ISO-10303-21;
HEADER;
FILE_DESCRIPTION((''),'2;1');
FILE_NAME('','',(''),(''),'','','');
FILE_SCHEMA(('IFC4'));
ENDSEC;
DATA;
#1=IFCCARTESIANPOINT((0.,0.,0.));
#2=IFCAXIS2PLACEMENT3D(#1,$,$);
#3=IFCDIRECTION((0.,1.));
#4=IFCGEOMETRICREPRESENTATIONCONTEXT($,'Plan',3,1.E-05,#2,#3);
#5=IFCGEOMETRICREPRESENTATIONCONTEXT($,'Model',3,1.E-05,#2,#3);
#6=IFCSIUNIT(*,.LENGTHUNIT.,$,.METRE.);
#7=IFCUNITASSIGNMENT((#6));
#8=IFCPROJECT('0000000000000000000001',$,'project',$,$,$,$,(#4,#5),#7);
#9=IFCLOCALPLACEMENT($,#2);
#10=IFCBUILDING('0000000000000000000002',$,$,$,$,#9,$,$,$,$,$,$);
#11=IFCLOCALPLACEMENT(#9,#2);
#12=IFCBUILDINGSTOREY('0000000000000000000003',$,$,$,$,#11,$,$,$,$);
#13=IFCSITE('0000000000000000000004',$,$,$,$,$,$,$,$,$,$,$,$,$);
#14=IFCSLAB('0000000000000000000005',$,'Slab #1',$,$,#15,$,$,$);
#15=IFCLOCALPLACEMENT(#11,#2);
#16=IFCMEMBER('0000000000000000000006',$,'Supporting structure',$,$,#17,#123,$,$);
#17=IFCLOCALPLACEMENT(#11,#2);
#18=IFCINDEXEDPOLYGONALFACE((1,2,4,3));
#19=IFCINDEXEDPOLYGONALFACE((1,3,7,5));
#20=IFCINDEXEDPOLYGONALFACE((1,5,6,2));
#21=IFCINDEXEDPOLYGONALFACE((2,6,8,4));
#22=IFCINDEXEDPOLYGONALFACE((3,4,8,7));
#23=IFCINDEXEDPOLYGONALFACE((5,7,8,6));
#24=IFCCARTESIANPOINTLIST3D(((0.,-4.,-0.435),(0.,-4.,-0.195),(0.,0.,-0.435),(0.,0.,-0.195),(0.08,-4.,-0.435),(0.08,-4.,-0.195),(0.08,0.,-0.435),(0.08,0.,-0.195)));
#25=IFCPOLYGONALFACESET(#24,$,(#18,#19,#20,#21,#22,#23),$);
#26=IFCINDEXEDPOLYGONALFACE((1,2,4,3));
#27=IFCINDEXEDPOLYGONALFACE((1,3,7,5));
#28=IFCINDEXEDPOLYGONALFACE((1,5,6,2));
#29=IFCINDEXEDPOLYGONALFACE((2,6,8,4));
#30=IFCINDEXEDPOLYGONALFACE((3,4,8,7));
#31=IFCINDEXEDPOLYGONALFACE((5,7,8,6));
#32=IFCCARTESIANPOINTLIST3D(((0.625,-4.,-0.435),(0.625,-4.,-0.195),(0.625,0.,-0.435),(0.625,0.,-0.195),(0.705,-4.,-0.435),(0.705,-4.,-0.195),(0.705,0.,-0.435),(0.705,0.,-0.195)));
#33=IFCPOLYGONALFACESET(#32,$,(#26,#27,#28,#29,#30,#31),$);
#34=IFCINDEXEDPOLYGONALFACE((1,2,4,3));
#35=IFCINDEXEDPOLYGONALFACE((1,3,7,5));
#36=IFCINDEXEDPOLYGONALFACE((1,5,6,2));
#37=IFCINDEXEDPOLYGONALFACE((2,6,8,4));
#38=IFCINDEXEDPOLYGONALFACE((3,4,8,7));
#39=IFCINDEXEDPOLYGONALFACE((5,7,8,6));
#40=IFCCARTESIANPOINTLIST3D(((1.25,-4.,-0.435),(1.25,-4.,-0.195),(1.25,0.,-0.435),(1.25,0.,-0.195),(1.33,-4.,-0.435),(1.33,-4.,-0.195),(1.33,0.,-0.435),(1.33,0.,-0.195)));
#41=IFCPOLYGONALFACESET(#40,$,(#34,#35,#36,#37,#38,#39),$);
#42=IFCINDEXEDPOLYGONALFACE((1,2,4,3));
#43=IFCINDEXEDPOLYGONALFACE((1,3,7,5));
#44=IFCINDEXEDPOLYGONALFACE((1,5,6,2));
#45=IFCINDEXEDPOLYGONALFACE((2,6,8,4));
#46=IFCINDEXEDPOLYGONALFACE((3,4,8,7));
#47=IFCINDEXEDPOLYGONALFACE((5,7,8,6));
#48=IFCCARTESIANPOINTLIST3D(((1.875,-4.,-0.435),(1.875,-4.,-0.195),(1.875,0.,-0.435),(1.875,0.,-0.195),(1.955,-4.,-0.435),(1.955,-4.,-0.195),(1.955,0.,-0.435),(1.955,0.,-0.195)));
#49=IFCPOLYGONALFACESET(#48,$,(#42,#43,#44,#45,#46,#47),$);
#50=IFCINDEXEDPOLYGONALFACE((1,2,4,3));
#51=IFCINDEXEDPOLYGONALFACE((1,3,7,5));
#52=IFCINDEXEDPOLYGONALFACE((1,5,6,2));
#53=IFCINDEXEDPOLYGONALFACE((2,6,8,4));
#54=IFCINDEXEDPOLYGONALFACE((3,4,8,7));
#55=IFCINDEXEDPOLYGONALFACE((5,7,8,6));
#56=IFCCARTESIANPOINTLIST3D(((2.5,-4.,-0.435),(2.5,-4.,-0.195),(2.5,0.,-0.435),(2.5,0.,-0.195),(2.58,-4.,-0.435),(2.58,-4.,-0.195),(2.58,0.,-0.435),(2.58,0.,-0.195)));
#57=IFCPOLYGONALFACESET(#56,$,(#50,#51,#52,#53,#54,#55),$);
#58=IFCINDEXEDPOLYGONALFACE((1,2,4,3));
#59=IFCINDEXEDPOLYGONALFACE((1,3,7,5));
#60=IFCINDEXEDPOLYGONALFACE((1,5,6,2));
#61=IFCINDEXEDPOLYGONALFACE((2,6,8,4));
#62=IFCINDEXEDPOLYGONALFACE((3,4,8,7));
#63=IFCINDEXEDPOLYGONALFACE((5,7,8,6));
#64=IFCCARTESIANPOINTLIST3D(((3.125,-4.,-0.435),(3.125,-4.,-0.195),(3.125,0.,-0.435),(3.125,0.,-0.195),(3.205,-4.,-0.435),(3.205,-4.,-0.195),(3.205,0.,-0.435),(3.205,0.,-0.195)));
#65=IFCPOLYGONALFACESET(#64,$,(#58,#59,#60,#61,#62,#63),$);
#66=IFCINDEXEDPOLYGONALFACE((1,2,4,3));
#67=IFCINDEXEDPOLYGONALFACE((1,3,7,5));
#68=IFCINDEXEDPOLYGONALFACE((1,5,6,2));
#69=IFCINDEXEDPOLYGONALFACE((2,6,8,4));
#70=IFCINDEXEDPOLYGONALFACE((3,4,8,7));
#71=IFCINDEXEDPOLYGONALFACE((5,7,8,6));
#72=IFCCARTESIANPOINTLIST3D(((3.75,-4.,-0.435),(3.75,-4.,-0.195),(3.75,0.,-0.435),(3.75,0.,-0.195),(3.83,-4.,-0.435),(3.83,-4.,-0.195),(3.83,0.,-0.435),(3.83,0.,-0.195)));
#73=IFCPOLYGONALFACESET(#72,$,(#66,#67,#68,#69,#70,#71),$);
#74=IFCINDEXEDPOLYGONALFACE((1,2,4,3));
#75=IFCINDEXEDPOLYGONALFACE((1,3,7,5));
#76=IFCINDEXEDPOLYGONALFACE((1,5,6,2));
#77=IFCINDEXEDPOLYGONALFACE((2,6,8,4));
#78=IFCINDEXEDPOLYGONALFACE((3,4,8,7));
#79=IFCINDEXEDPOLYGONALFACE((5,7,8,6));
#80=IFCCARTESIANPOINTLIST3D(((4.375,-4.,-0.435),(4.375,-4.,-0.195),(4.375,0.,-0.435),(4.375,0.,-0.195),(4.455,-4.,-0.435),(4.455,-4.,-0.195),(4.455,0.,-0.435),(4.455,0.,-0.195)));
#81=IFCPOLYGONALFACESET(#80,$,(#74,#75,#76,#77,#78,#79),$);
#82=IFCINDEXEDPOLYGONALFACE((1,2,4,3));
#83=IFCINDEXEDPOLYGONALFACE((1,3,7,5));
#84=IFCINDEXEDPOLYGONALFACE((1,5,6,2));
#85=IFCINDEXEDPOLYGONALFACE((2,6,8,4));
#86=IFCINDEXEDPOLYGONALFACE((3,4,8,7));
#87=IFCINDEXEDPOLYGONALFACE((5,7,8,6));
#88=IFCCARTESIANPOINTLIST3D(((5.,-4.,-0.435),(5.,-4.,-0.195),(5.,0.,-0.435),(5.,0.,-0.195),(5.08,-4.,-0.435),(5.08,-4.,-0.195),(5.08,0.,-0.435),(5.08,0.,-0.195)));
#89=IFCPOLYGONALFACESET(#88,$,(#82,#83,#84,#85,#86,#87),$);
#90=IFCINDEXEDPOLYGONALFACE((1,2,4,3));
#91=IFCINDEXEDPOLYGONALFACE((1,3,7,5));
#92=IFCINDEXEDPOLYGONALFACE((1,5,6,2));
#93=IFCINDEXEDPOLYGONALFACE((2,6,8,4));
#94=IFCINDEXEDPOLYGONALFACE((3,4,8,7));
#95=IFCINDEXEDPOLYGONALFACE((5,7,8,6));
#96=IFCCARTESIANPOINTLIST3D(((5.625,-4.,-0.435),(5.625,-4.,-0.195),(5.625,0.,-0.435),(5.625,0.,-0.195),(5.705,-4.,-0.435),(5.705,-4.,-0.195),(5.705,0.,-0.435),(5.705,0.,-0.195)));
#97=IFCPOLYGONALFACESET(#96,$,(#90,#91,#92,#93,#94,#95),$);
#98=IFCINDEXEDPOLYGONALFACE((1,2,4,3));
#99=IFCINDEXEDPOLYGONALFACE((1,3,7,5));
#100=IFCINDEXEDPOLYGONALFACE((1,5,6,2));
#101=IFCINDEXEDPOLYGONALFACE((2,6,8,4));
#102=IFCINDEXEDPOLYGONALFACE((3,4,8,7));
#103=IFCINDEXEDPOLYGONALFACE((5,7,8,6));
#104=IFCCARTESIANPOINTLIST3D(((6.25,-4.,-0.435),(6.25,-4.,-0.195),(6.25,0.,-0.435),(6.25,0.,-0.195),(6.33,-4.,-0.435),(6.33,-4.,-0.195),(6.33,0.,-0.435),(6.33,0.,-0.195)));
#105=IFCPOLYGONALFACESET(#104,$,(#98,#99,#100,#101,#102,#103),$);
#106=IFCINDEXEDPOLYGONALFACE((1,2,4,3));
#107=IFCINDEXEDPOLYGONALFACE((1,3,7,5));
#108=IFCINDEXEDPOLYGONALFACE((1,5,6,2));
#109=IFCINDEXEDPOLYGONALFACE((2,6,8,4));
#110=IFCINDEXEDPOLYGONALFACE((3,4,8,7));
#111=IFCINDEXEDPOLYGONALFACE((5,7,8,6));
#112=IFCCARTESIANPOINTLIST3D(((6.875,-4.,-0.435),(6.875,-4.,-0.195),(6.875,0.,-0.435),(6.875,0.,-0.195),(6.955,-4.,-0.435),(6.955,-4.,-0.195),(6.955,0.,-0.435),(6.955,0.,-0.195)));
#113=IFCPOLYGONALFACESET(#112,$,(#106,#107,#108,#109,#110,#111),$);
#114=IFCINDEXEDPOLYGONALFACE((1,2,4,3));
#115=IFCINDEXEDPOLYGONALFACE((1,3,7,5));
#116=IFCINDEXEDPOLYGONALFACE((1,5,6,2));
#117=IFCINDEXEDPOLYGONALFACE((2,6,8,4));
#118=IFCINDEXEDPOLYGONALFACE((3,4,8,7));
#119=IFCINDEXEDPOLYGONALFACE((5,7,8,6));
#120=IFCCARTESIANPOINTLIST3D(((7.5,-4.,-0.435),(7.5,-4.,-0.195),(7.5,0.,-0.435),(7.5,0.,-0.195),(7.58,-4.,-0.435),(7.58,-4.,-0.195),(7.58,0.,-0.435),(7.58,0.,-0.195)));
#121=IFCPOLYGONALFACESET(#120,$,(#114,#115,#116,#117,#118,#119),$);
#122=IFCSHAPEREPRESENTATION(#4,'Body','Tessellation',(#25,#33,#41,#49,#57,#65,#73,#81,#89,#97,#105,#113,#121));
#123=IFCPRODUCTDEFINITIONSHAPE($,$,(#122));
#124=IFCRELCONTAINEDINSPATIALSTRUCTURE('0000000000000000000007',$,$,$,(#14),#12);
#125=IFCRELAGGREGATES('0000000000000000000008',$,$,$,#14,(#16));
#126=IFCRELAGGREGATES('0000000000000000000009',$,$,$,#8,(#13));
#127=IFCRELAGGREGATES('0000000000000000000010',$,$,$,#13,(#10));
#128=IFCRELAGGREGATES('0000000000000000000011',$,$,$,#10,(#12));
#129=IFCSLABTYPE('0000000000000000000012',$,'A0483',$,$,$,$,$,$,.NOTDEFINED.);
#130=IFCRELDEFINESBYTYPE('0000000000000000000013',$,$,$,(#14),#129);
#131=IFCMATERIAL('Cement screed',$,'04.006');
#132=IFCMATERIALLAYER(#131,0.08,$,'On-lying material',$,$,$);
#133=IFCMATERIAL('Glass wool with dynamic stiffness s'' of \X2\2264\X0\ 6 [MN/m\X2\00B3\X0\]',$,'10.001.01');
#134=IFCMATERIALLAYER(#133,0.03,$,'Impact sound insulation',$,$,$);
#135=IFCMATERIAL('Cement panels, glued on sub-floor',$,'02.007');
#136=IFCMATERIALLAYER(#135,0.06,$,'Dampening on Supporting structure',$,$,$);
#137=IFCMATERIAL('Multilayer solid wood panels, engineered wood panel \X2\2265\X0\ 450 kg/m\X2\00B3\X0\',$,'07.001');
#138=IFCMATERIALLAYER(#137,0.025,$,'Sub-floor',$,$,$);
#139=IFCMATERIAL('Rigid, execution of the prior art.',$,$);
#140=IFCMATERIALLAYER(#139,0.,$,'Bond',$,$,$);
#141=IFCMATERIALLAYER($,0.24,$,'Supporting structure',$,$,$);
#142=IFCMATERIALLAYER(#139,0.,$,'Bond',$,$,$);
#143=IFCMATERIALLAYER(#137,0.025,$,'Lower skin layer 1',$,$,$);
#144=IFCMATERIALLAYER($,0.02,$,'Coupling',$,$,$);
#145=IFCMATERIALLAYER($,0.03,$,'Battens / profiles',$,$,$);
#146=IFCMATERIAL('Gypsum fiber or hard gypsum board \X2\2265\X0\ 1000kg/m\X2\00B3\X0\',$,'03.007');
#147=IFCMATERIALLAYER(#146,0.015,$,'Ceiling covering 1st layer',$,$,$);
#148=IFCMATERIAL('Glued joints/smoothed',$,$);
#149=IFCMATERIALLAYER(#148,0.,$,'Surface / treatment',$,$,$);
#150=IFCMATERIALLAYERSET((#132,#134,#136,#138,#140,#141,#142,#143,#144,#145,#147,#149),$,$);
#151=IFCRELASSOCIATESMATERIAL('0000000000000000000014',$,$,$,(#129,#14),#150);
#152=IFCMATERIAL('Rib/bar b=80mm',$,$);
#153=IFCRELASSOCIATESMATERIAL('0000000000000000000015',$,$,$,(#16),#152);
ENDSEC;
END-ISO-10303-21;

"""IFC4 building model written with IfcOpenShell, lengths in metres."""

from ifc_helpers import new_model, si_unit, direction, frame, frame_2d, origin, place, context, project, spatial, rectangle, extrude, material, layer, layer_set, type_object, element, aggregate, save


model = new_model("IFC4")

# Units and contexts
plan_context = context("Plan", 3, precision=1e-05, world=origin(), true_north=direction((0.0, 1.0)))
model_context = context("Model", 3, precision=1e-05, world=origin(), true_north=direction((0.0, 1.0)))
ifc_project = project(units=[si_unit("LENGTHUNIT", "METRE")], contexts=[plan_context, model_context])

# Site, building, storey
site = spatial("IfcSite", under=ifc_project)
building_placement = place(None, origin())
building = spatial("IfcBuilding", under=site, at=building_placement)
storey_placement = place(building_placement, origin())
storey = spatial("IfcBuildingStorey", under=building, at=storey_placement)

# Slab, member
ifc_material_1 = material(Name="Cement screed", Category="04.006")
ifc_layer_1 = layer(ifc_material_1, 0.08, Name="On-lying material")
ifc_material_2 = material(Name="Glass wool with dynamic stiffness s' of ≤ 6 [MN/m³]", Category="10.001.01")
ifc_layer_2 = layer(ifc_material_2, 0.03, Name="Impact sound insulation")
ifc_material_3 = material(Name="Cement panels, glued on sub-floor", Category="02.007")
ifc_layer_3 = layer(ifc_material_3, 0.06, Name="Dampening on Supporting structure")
ifc_material_4 = material(Name="Multilayer solid wood panels, engineered wood panel ≥ 450 kg/m³", Category="07.001")
ifc_layer_4 = layer(ifc_material_4, 0.025, Name="Sub-floor")
ifc_material_5 = material(Name="Rigid, execution of the prior art.")
ifc_layer_5 = layer(ifc_material_5, 0.0, Name="Bond")
ifc_layer_6 = layer(None, 0.24, Name="Supporting structure")
ifc_layer_7 = layer(ifc_material_5, 0.0, Name="Bond")
ifc_layer_8 = layer(ifc_material_4, 0.025, Name="Lower skin layer 1")
ifc_layer_9 = layer(None, 0.02, Name="Coupling")
ifc_layer_10 = layer(None, 0.03, Name="Battens / profiles")
ifc_material_6 = material(Name="Gypsum fiber or hard gypsum board ≥ 1000kg/m³", Category="03.007")
ifc_layer_11 = layer(ifc_material_6, 0.015, Name="Ceiling covering 1st layer")
ifc_material_7 = material(Name="Glued joints/smoothed")
ifc_layer_12 = layer(ifc_material_7, 0.0, Name="Surface / treatment")
ifc_layer_set = layer_set([ifc_layer_1, ifc_layer_2, ifc_layer_3, ifc_layer_4, ifc_layer_5, ifc_layer_6, ifc_layer_7, ifc_layer_8, ifc_layer_9, ifc_layer_10, ifc_layer_11, ifc_layer_12])
slab_type = type_object("IfcSlabType", Name="A0483", PredefinedType="NOTDEFINED", material=ifc_layer_set)
slab_placement = place(None, frame((0.0, 0.0, 0.0), z_axis=(0.0, 0.0, -1.0), x_axis=(1.0, 0.0, 0.0)))
slab = element("IfcSlab", 1, at=slab_placement, inside=storey, type_object=slab_type, material=ifc_layer_set, Name="Slab #1")
ifc_material_8 = material(Name="Rib/bar b=80mm")
member_1_placement = place(slab_placement, origin())
member_1 = element("IfcMember", 2, at=member_1_placement, material=ifc_material_8, Name="Supporting structure", context=plan_context, shape_type="SweptSolid", body=[
    extrude(rectangle(XDim=0.08, YDim=0.24, at=frame_2d((0.04, 0.12), x_axis=(1.0, 0.0))), frame((0.0, 4.0, 0.195), z_axis=(0.0, -1.0, 0.0), x_axis=(1.0, 0.0, 0.0)), (0.0, 0.0, 1.0), 4.0),
    extrude(rectangle(XDim=0.08, YDim=0.24, at=frame_2d((0.04, 0.12), x_axis=(1.0, 0.0))), frame((0.625, 4.0, 0.195), z_axis=(0.0, -1.0, 0.0), x_axis=(1.0, 0.0, 0.0)), (0.0, 0.0, 1.0), 4.0),
    extrude(rectangle(XDim=0.08, YDim=0.24, at=frame_2d((0.04, 0.12), x_axis=(1.0, 0.0))), frame((1.25, 4.0, 0.195), z_axis=(0.0, -1.0, 0.0), x_axis=(1.0, 0.0, 0.0)), (0.0, 0.0, 1.0), 4.0),
    extrude(rectangle(XDim=0.08, YDim=0.24, at=frame_2d((0.04, 0.12), x_axis=(1.0, 0.0))), frame((1.875, 4.0, 0.195), z_axis=(0.0, -1.0, 0.0), x_axis=(1.0, 0.0, 0.0)), (0.0, 0.0, 1.0), 4.0),
    extrude(rectangle(XDim=0.08, YDim=0.24, at=frame_2d((0.04, 0.12), x_axis=(1.0, 0.0))), frame((2.5, 4.0, 0.195), z_axis=(0.0, -1.0, 0.0), x_axis=(1.0, 0.0, 0.0)), (0.0, 0.0, 1.0), 4.0),
    extrude(rectangle(XDim=0.08, YDim=0.24, at=frame_2d((0.04, 0.12), x_axis=(1.0, 0.0))), frame((3.125, 4.0, 0.195), z_axis=(0.0, -1.0, 0.0), x_axis=(1.0, 0.0, 0.0)), (0.0, 0.0, 1.0), 4.0),
    extrude(rectangle(XDim=0.08, YDim=0.24, at=frame_2d((0.04, 0.12), x_axis=(1.0, 0.0))), frame((3.75, 4.0, 0.195), z_axis=(0.0, -1.0, 0.0), x_axis=(1.0, 0.0, 0.0)), (0.0, 0.0, 1.0), 4.0),
    extrude(rectangle(XDim=0.08, YDim=0.24, at=frame_2d((0.04, 0.12), x_axis=(1.0, 0.0))), frame((4.375, 4.0, 0.195), z_axis=(0.0, -1.0, 0.0), x_axis=(1.0, 0.0, 0.0)), (0.0, 0.0, 1.0), 4.0),
    extrude(rectangle(XDim=0.08, YDim=0.24, at=frame_2d((0.04, 0.12), x_axis=(1.0, 0.0))), frame((5.0, 4.0, 0.195), z_axis=(0.0, -1.0, 0.0), x_axis=(1.0, 0.0, 0.0)), (0.0, 0.0, 1.0), 4.0),
    extrude(rectangle(XDim=0.08, YDim=0.24, at=frame_2d((0.04, 0.12), x_axis=(1.0, 0.0))), frame((5.625, 4.0, 0.195), z_axis=(0.0, -1.0, 0.0), x_axis=(1.0, 0.0, 0.0)), (0.0, 0.0, 1.0), 4.0),
    extrude(rectangle(XDim=0.08, YDim=0.24, at=frame_2d((0.04, 0.12), x_axis=(1.0, 0.0))), frame((6.25, 4.0, 0.195), z_axis=(0.0, -1.0, 0.0), x_axis=(1.0, 0.0, 0.0)), (0.0, 0.0, 1.0), 4.0),
    extrude(rectangle(XDim=0.08, YDim=0.24, at=frame_2d((0.04, 0.12), x_axis=(1.0, 0.0))), frame((6.875, 4.0, 0.195), z_axis=(0.0, -1.0, 0.0), x_axis=(1.0, 0.0, 0.0)), (0.0, 0.0, 1.0), 4.0),
    extrude(rectangle(XDim=0.08, YDim=0.24, at=frame_2d((0.04, 0.12), x_axis=(1.0, 0.0))), frame((7.5, 4.0, 0.195), z_axis=(0.0, -1.0, 0.0), x_axis=(1.0, 0.0, 0.0)), (0.0, 0.0, 1.0), 4.0),
])
aggregate(slab, [member_1])

save(model, "model.ifc")
